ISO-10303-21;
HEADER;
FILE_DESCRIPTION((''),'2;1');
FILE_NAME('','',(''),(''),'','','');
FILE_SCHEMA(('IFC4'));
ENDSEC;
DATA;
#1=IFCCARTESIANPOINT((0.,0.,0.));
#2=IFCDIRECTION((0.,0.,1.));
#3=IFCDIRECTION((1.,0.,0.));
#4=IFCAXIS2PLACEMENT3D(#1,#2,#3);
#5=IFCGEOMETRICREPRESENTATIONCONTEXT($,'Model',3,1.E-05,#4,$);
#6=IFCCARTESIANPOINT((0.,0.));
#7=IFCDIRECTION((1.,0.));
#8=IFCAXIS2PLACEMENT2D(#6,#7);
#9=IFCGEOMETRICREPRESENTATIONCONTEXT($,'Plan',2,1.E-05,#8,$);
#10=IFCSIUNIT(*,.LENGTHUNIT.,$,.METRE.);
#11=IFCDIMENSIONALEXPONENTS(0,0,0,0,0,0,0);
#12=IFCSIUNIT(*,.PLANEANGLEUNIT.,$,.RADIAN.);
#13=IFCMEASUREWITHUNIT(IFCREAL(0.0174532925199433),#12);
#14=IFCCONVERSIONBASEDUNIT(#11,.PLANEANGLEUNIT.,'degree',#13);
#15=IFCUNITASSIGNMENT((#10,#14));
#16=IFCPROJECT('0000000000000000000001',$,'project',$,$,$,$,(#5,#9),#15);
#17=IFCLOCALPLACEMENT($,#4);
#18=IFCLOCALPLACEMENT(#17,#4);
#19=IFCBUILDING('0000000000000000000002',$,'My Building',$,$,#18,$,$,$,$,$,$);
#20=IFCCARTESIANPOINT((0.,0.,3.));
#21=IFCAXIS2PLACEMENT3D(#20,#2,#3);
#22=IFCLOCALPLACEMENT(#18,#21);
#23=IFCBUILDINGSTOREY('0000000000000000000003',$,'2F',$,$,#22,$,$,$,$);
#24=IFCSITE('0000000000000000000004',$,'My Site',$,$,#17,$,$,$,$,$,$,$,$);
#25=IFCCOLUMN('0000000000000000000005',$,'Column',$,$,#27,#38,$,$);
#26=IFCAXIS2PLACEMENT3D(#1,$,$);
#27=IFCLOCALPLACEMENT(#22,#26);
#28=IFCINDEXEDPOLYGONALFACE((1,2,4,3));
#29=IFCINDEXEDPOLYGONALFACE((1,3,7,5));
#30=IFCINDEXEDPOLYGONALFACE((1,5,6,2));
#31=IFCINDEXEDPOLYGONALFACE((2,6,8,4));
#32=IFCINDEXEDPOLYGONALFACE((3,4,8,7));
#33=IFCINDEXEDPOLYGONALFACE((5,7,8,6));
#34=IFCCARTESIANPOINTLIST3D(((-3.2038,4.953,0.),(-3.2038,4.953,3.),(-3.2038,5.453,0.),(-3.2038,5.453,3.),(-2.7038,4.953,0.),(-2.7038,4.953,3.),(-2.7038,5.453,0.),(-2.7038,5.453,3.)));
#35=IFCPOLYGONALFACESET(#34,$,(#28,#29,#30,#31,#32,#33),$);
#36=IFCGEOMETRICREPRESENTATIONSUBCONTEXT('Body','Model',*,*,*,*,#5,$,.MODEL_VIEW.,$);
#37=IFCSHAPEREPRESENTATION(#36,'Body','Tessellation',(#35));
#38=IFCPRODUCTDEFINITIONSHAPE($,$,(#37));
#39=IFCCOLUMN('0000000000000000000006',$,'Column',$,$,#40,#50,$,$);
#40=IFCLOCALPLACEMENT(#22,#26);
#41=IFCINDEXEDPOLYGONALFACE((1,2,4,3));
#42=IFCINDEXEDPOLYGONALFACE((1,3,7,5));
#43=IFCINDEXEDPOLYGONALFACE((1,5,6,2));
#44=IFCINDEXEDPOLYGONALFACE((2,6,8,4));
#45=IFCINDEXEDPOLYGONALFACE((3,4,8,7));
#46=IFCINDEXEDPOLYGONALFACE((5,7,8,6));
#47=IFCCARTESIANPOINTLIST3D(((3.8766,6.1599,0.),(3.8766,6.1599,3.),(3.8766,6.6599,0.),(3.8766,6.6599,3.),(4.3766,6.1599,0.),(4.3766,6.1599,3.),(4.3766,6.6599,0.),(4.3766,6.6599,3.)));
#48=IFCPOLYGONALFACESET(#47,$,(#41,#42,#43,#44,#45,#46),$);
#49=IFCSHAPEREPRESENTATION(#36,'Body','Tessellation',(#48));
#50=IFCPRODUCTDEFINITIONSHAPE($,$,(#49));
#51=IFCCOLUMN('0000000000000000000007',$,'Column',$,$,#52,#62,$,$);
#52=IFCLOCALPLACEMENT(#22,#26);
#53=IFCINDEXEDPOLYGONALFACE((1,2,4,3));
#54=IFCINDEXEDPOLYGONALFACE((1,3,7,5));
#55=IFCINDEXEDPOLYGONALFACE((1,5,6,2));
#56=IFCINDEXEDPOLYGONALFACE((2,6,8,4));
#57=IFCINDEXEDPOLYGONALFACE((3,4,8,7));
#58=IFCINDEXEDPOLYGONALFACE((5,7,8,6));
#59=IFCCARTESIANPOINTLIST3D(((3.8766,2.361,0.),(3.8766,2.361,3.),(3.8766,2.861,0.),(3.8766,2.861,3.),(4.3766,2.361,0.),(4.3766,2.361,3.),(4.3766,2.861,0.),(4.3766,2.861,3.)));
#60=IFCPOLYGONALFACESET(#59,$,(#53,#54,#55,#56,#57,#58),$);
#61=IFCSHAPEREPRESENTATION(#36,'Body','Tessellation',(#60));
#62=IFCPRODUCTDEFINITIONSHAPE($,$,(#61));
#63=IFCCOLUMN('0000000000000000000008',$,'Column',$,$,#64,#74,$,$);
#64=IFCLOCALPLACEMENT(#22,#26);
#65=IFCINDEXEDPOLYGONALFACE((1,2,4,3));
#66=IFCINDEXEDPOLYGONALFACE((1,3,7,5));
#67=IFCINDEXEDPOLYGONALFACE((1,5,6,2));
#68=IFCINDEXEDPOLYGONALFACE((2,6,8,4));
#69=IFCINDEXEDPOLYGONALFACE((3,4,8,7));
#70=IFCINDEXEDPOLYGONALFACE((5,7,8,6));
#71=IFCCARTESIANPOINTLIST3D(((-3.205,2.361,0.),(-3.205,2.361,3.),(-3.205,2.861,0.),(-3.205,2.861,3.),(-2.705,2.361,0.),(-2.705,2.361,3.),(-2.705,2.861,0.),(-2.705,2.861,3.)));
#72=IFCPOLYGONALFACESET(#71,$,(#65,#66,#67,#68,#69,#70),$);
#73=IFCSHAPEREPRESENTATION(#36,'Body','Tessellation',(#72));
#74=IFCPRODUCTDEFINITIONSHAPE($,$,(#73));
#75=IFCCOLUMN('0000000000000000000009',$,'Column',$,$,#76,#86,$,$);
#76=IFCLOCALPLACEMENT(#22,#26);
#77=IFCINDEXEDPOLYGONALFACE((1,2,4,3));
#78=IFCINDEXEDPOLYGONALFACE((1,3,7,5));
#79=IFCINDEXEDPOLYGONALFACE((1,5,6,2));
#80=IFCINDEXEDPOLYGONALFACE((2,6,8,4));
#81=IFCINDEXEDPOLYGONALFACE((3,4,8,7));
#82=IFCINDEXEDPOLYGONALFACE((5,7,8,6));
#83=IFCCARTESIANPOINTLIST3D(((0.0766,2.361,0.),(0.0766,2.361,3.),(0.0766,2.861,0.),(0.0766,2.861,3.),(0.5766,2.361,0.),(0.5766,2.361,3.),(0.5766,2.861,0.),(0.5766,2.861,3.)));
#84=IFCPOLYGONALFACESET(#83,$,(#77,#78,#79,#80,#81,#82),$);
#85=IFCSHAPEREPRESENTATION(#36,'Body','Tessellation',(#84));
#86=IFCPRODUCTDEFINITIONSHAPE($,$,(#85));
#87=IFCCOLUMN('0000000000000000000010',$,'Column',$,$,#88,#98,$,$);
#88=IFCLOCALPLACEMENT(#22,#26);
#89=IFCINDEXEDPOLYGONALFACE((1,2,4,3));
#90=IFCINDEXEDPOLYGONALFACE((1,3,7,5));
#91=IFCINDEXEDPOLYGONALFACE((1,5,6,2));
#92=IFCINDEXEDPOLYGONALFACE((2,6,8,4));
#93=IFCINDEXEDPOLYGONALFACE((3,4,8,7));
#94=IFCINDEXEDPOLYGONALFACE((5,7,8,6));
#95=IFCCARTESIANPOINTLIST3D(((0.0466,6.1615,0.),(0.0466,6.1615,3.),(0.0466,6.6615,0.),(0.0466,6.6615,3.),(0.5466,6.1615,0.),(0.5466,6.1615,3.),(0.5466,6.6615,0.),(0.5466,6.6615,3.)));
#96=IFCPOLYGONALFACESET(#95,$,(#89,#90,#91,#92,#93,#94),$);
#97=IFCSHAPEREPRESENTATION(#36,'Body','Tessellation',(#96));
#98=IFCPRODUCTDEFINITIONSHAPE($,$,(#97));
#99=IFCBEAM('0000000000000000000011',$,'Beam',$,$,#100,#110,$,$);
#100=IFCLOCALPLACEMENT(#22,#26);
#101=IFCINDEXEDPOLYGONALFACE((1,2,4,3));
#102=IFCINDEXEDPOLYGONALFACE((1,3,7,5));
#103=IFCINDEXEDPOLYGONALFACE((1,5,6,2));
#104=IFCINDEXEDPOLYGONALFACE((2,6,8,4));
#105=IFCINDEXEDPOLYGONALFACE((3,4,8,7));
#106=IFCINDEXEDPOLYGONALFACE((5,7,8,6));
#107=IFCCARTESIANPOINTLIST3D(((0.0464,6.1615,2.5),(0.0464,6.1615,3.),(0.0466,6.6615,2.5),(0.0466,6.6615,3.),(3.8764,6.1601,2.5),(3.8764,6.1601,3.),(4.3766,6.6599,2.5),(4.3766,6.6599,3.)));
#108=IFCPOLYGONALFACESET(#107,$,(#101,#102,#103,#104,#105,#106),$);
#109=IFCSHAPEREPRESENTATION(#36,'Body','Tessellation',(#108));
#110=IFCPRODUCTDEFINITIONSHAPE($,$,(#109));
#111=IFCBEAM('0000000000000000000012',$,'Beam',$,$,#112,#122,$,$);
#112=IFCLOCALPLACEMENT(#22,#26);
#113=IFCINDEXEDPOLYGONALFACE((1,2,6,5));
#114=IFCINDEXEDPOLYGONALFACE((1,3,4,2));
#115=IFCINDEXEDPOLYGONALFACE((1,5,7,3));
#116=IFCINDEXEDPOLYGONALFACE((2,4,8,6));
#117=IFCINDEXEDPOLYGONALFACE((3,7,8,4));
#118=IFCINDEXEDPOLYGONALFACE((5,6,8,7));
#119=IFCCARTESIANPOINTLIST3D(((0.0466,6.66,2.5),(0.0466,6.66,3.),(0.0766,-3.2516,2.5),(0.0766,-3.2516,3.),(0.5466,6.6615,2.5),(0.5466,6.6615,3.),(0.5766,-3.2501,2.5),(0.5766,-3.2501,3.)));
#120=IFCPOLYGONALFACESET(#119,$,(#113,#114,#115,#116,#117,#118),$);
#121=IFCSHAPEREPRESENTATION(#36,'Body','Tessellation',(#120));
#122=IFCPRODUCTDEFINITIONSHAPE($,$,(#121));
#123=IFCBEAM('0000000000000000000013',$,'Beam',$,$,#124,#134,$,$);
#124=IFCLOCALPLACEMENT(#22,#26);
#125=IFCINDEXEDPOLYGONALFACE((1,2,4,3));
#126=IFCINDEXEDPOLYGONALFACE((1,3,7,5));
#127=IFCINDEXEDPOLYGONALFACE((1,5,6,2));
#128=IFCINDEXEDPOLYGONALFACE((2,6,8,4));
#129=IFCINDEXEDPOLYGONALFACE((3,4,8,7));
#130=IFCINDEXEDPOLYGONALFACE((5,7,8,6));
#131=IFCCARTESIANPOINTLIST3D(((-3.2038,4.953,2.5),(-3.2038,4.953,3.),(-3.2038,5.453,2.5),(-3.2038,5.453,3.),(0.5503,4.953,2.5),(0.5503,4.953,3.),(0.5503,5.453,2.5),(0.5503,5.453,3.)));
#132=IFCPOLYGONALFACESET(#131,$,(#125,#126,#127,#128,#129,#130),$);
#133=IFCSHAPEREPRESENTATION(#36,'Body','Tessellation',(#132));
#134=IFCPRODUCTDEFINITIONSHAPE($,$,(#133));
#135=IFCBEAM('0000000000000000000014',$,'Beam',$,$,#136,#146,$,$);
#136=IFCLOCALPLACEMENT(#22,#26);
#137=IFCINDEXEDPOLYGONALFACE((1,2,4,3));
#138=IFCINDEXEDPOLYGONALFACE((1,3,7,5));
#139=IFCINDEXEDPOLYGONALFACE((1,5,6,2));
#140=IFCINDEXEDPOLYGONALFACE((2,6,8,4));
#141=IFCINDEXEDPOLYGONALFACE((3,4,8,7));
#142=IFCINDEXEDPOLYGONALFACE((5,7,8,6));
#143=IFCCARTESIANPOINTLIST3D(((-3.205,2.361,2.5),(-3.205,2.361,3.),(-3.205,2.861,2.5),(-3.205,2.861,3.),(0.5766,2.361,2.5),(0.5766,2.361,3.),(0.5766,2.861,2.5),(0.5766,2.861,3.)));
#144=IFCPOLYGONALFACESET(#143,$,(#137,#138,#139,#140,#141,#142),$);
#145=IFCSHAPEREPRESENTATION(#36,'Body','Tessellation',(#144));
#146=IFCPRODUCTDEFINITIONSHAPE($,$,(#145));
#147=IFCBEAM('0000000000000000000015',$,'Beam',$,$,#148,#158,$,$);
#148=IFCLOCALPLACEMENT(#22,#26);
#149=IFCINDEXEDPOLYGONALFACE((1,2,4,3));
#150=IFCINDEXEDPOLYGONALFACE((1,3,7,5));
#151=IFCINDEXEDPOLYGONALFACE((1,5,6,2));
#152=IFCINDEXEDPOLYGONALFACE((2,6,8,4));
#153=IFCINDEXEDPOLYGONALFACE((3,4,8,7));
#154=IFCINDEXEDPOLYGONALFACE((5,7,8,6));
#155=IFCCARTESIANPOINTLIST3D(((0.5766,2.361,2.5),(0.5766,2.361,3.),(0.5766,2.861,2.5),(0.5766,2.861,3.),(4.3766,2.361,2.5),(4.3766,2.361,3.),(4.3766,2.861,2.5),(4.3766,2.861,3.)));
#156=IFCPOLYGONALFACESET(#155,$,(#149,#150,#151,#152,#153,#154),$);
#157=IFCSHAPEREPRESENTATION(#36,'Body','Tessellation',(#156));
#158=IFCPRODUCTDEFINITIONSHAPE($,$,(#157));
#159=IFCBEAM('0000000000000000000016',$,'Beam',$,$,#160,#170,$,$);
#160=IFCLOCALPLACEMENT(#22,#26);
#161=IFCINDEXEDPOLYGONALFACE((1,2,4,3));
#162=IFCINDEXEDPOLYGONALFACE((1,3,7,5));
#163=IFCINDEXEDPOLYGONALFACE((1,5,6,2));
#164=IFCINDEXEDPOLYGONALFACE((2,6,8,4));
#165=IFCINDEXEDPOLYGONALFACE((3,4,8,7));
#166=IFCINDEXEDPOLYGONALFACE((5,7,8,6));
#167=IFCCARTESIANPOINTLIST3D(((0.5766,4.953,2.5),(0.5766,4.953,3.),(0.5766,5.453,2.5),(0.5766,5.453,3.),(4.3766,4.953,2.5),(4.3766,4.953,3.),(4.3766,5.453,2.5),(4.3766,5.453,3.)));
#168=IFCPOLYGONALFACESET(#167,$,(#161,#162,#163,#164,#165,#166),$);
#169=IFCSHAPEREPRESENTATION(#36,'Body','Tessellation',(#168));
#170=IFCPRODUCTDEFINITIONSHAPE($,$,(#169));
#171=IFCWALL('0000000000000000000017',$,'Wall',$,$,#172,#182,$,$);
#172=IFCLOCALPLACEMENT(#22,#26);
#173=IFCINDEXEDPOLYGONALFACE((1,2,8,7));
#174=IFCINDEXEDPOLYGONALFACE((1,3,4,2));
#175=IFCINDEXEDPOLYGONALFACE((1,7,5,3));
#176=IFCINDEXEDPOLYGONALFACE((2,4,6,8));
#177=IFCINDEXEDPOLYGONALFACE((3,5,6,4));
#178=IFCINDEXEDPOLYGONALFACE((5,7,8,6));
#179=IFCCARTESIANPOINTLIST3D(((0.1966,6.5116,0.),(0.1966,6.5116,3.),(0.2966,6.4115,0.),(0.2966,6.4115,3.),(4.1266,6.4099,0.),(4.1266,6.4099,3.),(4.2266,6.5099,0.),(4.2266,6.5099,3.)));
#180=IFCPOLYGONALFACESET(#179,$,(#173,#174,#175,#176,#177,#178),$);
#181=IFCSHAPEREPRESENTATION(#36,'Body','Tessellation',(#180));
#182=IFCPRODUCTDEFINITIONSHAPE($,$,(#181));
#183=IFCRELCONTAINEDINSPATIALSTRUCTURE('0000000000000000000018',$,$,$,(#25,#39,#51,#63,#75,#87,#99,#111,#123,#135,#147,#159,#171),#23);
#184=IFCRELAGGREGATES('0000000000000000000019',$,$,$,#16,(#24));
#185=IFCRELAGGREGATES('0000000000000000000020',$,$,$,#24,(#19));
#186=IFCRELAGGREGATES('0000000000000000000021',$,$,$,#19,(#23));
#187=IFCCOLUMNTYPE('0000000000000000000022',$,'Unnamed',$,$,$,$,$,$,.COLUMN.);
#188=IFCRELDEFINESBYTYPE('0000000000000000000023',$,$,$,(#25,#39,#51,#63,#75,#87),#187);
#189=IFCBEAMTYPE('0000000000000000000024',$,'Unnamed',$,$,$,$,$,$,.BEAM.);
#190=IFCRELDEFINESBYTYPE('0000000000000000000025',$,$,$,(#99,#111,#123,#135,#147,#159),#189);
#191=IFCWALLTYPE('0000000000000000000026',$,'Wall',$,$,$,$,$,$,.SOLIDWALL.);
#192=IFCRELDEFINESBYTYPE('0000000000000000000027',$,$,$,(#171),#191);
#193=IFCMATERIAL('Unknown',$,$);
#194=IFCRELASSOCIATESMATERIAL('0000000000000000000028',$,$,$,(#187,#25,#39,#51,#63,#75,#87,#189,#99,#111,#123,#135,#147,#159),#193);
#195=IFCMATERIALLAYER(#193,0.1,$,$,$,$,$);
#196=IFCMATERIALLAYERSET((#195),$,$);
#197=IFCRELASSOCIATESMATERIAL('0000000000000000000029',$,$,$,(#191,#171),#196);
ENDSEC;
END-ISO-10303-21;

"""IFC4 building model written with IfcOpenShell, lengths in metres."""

from ifc_helpers import new_model, entity, si_unit, converted_unit, frame, origin_with_axes, origin_2d_with_axis, place, context, subcontext, project, spatial, line, indexed_curve, rectangle, outline, extrude, clip, halfspace, material, layer, layer_set, layer_usage, material_profile, profile_set, profile_usage, type_object, element, save


model = new_model("IFC4")

# Units and contexts
model_context = context("Model", 3, precision=1e-05, world=origin_with_axes())
plan_context = context("Plan", 2, precision=1e-05, world=origin_2d_with_axis())
body_context_1 = subcontext(model_context, "Body", "Model", "MODEL_VIEW")
ifc_project = project(units=[si_unit("LENGTHUNIT", "METRE"), converted_unit("PLANEANGLEUNIT", "degree", entity("IfcReal", 0.0174532925199433), si_unit("PLANEANGLEUNIT", "RADIAN"), dimensions=[0, 0, 0, 0, 0, 0, 0])], contexts=[model_context, plan_context])

# Site, building, storey
site_placement = place(None, origin_with_axes())
site = spatial("IfcSite", under=ifc_project, at=site_placement, Name="My Site")
building_placement = place(site_placement, origin_with_axes())
building = spatial("IfcBuilding", under=site, at=building_placement, Name="My Building")
storey_placement = place(building_placement, frame((0.0, 0.0, 3.0), z_axis=(0.0, 0.0, 1.0), x_axis=(1.0, 0.0, 0.0)))
storey = spatial("IfcBuildingStorey", under=building, at=storey_placement, Name="2F")

# Columns
ifc_material = material(Name="Unknown")
ifc_material_profile_1 = material_profile(ifc_material, rectangle(XDim=0.5, YDim=0.5))
ifc_profile_set_1 = profile_set([ifc_material_profile_1])
ifc_profile_usage_1 = profile_usage(ifc_profile_set_1, cardinal=9)
column_type = type_object("IfcColumnType", Name="Unnamed", PredefinedType="COLUMN", material=ifc_profile_set_1)
column_1_placement = place(storey_placement, frame((-3.2038, 5.453, 0.0), z_axis=(0.0, 0.0, 1.0), x_axis=(1.0, 0.0, 0.0)))
element("IfcColumn", 1, at=column_1_placement, inside=storey, type_object=column_type, material=ifc_profile_usage_1, Name="Column", context=body_context_1, shape_type="SweptSolid", body=[
    extrude(rectangle(XDim=0.5, YDim=0.5), frame((0.25, -0.25, 0.0), z_axis=(0.0, 0.0, 1.0), x_axis=(1.0, 0.0, 0.0)), (0.0, 0.0, 1.0), 3.0),
])
ifc_profile_usage_2 = profile_usage(ifc_profile_set_1, cardinal=9)
column_2_placement = place(storey_placement, frame((3.8766, 6.6599, 0.0), z_axis=(0.0, 0.0, 1.0), x_axis=(1.0, 0.0, 0.0)))
element("IfcColumn", 2, at=column_2_placement, inside=storey, type_object=column_type, material=ifc_profile_usage_2, Name="Column", context=body_context_1, shape_type="SweptSolid", body=[
    extrude(rectangle(XDim=0.5, YDim=0.5), frame((0.25, -0.25, 0.0), z_axis=(0.0, 0.0, 1.0), x_axis=(1.0, 0.0, 0.0)), (0.0, 0.0, 1.0), 3.0),
])
ifc_profile_usage_3 = profile_usage(ifc_profile_set_1, cardinal=7)
column_3_placement = place(storey_placement, frame((4.3766, 2.861, 0.0), z_axis=(0.0, 0.0, 1.0), x_axis=(1.0, 0.0, 0.0)))
element("IfcColumn", 3, at=column_3_placement, inside=storey, type_object=column_type, material=ifc_profile_usage_3, Name="Column", context=body_context_1, shape_type="SweptSolid", body=[
    extrude(rectangle(XDim=0.5, YDim=0.5), frame((-0.25, -0.25, 0.0), z_axis=(0.0, 0.0, 1.0), x_axis=(1.0, 0.0, 0.0)), (0.0, 0.0, 1.0), 3.0),
])
ifc_profile_usage_4 = profile_usage(ifc_profile_set_1, cardinal=7)
column_4_placement = place(storey_placement, frame((-2.705, 2.861, 0.0), z_axis=(0.0, 0.0, 1.0), x_axis=(1.0, 0.0, 0.0)))
element("IfcColumn", 4, at=column_4_placement, inside=storey, type_object=column_type, material=ifc_profile_usage_4, Name="Column", context=body_context_1, shape_type="SweptSolid", body=[
    extrude(rectangle(XDim=0.5, YDim=0.5), frame((-0.25, -0.25, 0.0), z_axis=(0.0, 0.0, 1.0), x_axis=(1.0, 0.0, 0.0)), (0.0, 0.0, 1.0), 3.0),
])
ifc_profile_usage_5 = profile_usage(ifc_profile_set_1, cardinal=7)
column_5_placement = place(storey_placement, frame((0.5766, 2.861, 0.0), z_axis=(0.0, 0.0, 1.0), x_axis=(1.0, 0.0, 0.0)))
element("IfcColumn", 5, at=column_5_placement, inside=storey, type_object=column_type, material=ifc_profile_usage_5, Name="Column", context=body_context_1, shape_type="SweptSolid", body=[
    extrude(rectangle(XDim=0.5, YDim=0.5), frame((-0.25, -0.25, 0.0), z_axis=(0.0, 0.0, 1.0), x_axis=(1.0, 0.0, 0.0)), (0.0, 0.0, 1.0), 3.0),
])
ifc_profile_usage_6 = profile_usage(ifc_profile_set_1, cardinal=7)
column_6_placement = place(storey_placement, frame((0.5466, 6.6615, 0.0), z_axis=(0.0, 0.0, 1.0), x_axis=(1.0, 0.0, 0.0)))
element("IfcColumn", 6, at=column_6_placement, inside=storey, type_object=column_type, material=ifc_profile_usage_6, Name="Column", context=body_context_1, shape_type="SweptSolid", body=[
    extrude(rectangle(XDim=0.5, YDim=0.5), frame((-0.25, -0.25, 0.0), z_axis=(0.0, 0.0, 1.0), x_axis=(1.0, 0.0, 0.0)), (0.0, 0.0, 1.0), 3.0),
])

# Beams
ifc_material_profile_2 = material_profile(ifc_material, rectangle(XDim=0.5, YDim=0.5))
ifc_profile_set_2 = profile_set([ifc_material_profile_2])
ifc_profile_usage_7 = profile_usage(ifc_profile_set_2, cardinal=7)
beam_type = type_object("IfcBeamType", Name="Unnamed", PredefinedType="BEAM", material=ifc_profile_set_2)
beam_1_placement = place(storey_placement, frame((0.0466, 6.6615, 3.0), z_axis=(1.0, -0.000377, 0.0), x_axis=(0.000377, 1.0, 0.0)))
element("IfcBeam", 7, at=beam_1_placement, inside=storey, type_object=beam_type, material=ifc_profile_usage_7, Name="Beam", context=body_context_1, shape_type="Clipping", body=[
    clip(extrude(rectangle(XDim=0.5, YDim=0.5), frame((-0.25, -0.25, 0.0), z_axis=(0.0, 0.0, 1.0), x_axis=(1.0, 0.0, 0.0)), (0.0, 0.0, 1.0), 4.83), halfspace(frame((0.0, -6.0, 4.33), z_axis=(-0.707114, 0.0, 0.707099), x_axis=(0.0, 1.0, 0.0)), False)),
])
ifc_profile_usage_8 = profile_usage(ifc_profile_set_2, cardinal=7)
beam_2_placement = place(storey_placement, frame((0.5466, 6.6615, 3.0), z_axis=(0.003031, -0.999995, 0.0), x_axis=(0.999995, 0.003031, 0.0)))
element("IfcBeam", 8, at=beam_2_placement, inside=storey, type_object=beam_type, material=ifc_profile_usage_8, Name="Beam", context=body_context_1, shape_type="SweptSolid", body=[
    extrude(rectangle(XDim=0.5, YDim=0.5), frame((-0.25, -0.25, 0.0), z_axis=(0.0, 0.0, 1.0), x_axis=(1.0, 0.0, 0.0)), (0.0, 0.0, 1.0), 9.9117),
])
ifc_profile_usage_9 = profile_usage(ifc_profile_set_2, cardinal=7)
beam_3_placement = place(storey_placement, frame((-3.2038, 5.453, 3.0), z_axis=(1.0, 0.0, 0.000001), x_axis=(0.0, 1.0, 0.0)))
element("IfcBeam", 9, at=beam_3_placement, inside=storey, type_object=beam_type, material=ifc_profile_usage_9, Name="Beam", context=body_context_1, shape_type="SweptSolid", body=[
    extrude(rectangle(XDim=0.5, YDim=0.5), frame((-0.25, -0.25, 0.0), z_axis=(0.0, 0.0, 1.0), x_axis=(1.0, 0.0, 0.0)), (0.0, 0.0, 1.0), 3.7541),
])
ifc_profile_usage_10 = profile_usage(ifc_profile_set_2, cardinal=7)
beam_4_placement = place(storey_placement, frame((-3.205, 2.861, 3.0), z_axis=(1.0, 0.0, 0.0), x_axis=(0.0, 1.0, 0.0)))
element("IfcBeam", 10, at=beam_4_placement, inside=storey, type_object=beam_type, material=ifc_profile_usage_10, Name="Beam", context=body_context_1, shape_type="SweptSolid", body=[
    extrude(rectangle(XDim=0.5, YDim=0.5), frame((-0.25, -0.25, 0.0), z_axis=(0.0, 0.0, 1.0), x_axis=(1.0, 0.0, 0.0)), (0.0, 0.0, 1.0), 3.7816),
])
ifc_profile_usage_11 = profile_usage(ifc_profile_set_2, cardinal=7)
beam_5_placement = place(storey_placement, frame((0.5766, 2.861, 3.0), z_axis=(1.0, 0.000001, 0.0), x_axis=(-0.000001, 1.0, 0.0)))
element("IfcBeam", 11, at=beam_5_placement, inside=storey, type_object=beam_type, material=ifc_profile_usage_11, Name="Beam", context=body_context_1, shape_type="SweptSolid", body=[
    extrude(rectangle(XDim=0.5, YDim=0.5), frame((-0.25, -0.25, 0.0), z_axis=(0.0, 0.0, 1.0), x_axis=(1.0, 0.0, 0.0)), (0.0, 0.0, 1.0), 3.8),
])
ifc_profile_usage_12 = profile_usage(ifc_profile_set_2, cardinal=7)
beam_6_placement = place(storey_placement, frame((0.5766, 5.453, 3.0), z_axis=(1.0, 0.000001, 0.0), x_axis=(-0.000001, 1.0, 0.0)))
element("IfcBeam", 12, at=beam_6_placement, inside=storey, type_object=beam_type, material=ifc_profile_usage_12, Name="Beam", context=body_context_1, shape_type="SweptSolid", body=[
    extrude(rectangle(XDim=0.5, YDim=0.5), frame((-0.25, -0.25, 0.0), z_axis=(0.0, 0.0, 1.0), x_axis=(1.0, 0.0, 0.0)), (0.0, 0.0, 1.0), 3.8),
])

# Wall
ifc_layer = layer(ifc_material, 0.1)
ifc_layer_set = layer_set([ifc_layer])
ifc_layer_usage_1 = layer_usage(ifc_layer_set, "AXIS2", "POSITIVE", 0.0)
wall_type = type_object("IfcWallType", Name="Wall", PredefinedType="SOLIDWALL", material=ifc_layer_set)
wall_1_placement = place(storey_placement, frame((4.2266, 6.5099, 0.0), z_axis=(0.0, 0.0, 1.0), x_axis=(-1.0, 0.000415, 0.0)))
element("IfcWall", 13, at=wall_1_placement, inside=storey, type_object=wall_type, material=ifc_layer_usage_1, Name="Wall", context=body_context_1, shape_type="SweptSolid", body=[
    extrude(outline(indexed_curve([(0.0, 0.0), (0.1, 0.1), (3.93, 0.1), (4.03, 0.0)], segments=[line(1, 2, 3, 4, 1)])), origin_with_axes(), (0.0, 0.0, 1.0), 3.0),
])

save(model, "model.ifc")
